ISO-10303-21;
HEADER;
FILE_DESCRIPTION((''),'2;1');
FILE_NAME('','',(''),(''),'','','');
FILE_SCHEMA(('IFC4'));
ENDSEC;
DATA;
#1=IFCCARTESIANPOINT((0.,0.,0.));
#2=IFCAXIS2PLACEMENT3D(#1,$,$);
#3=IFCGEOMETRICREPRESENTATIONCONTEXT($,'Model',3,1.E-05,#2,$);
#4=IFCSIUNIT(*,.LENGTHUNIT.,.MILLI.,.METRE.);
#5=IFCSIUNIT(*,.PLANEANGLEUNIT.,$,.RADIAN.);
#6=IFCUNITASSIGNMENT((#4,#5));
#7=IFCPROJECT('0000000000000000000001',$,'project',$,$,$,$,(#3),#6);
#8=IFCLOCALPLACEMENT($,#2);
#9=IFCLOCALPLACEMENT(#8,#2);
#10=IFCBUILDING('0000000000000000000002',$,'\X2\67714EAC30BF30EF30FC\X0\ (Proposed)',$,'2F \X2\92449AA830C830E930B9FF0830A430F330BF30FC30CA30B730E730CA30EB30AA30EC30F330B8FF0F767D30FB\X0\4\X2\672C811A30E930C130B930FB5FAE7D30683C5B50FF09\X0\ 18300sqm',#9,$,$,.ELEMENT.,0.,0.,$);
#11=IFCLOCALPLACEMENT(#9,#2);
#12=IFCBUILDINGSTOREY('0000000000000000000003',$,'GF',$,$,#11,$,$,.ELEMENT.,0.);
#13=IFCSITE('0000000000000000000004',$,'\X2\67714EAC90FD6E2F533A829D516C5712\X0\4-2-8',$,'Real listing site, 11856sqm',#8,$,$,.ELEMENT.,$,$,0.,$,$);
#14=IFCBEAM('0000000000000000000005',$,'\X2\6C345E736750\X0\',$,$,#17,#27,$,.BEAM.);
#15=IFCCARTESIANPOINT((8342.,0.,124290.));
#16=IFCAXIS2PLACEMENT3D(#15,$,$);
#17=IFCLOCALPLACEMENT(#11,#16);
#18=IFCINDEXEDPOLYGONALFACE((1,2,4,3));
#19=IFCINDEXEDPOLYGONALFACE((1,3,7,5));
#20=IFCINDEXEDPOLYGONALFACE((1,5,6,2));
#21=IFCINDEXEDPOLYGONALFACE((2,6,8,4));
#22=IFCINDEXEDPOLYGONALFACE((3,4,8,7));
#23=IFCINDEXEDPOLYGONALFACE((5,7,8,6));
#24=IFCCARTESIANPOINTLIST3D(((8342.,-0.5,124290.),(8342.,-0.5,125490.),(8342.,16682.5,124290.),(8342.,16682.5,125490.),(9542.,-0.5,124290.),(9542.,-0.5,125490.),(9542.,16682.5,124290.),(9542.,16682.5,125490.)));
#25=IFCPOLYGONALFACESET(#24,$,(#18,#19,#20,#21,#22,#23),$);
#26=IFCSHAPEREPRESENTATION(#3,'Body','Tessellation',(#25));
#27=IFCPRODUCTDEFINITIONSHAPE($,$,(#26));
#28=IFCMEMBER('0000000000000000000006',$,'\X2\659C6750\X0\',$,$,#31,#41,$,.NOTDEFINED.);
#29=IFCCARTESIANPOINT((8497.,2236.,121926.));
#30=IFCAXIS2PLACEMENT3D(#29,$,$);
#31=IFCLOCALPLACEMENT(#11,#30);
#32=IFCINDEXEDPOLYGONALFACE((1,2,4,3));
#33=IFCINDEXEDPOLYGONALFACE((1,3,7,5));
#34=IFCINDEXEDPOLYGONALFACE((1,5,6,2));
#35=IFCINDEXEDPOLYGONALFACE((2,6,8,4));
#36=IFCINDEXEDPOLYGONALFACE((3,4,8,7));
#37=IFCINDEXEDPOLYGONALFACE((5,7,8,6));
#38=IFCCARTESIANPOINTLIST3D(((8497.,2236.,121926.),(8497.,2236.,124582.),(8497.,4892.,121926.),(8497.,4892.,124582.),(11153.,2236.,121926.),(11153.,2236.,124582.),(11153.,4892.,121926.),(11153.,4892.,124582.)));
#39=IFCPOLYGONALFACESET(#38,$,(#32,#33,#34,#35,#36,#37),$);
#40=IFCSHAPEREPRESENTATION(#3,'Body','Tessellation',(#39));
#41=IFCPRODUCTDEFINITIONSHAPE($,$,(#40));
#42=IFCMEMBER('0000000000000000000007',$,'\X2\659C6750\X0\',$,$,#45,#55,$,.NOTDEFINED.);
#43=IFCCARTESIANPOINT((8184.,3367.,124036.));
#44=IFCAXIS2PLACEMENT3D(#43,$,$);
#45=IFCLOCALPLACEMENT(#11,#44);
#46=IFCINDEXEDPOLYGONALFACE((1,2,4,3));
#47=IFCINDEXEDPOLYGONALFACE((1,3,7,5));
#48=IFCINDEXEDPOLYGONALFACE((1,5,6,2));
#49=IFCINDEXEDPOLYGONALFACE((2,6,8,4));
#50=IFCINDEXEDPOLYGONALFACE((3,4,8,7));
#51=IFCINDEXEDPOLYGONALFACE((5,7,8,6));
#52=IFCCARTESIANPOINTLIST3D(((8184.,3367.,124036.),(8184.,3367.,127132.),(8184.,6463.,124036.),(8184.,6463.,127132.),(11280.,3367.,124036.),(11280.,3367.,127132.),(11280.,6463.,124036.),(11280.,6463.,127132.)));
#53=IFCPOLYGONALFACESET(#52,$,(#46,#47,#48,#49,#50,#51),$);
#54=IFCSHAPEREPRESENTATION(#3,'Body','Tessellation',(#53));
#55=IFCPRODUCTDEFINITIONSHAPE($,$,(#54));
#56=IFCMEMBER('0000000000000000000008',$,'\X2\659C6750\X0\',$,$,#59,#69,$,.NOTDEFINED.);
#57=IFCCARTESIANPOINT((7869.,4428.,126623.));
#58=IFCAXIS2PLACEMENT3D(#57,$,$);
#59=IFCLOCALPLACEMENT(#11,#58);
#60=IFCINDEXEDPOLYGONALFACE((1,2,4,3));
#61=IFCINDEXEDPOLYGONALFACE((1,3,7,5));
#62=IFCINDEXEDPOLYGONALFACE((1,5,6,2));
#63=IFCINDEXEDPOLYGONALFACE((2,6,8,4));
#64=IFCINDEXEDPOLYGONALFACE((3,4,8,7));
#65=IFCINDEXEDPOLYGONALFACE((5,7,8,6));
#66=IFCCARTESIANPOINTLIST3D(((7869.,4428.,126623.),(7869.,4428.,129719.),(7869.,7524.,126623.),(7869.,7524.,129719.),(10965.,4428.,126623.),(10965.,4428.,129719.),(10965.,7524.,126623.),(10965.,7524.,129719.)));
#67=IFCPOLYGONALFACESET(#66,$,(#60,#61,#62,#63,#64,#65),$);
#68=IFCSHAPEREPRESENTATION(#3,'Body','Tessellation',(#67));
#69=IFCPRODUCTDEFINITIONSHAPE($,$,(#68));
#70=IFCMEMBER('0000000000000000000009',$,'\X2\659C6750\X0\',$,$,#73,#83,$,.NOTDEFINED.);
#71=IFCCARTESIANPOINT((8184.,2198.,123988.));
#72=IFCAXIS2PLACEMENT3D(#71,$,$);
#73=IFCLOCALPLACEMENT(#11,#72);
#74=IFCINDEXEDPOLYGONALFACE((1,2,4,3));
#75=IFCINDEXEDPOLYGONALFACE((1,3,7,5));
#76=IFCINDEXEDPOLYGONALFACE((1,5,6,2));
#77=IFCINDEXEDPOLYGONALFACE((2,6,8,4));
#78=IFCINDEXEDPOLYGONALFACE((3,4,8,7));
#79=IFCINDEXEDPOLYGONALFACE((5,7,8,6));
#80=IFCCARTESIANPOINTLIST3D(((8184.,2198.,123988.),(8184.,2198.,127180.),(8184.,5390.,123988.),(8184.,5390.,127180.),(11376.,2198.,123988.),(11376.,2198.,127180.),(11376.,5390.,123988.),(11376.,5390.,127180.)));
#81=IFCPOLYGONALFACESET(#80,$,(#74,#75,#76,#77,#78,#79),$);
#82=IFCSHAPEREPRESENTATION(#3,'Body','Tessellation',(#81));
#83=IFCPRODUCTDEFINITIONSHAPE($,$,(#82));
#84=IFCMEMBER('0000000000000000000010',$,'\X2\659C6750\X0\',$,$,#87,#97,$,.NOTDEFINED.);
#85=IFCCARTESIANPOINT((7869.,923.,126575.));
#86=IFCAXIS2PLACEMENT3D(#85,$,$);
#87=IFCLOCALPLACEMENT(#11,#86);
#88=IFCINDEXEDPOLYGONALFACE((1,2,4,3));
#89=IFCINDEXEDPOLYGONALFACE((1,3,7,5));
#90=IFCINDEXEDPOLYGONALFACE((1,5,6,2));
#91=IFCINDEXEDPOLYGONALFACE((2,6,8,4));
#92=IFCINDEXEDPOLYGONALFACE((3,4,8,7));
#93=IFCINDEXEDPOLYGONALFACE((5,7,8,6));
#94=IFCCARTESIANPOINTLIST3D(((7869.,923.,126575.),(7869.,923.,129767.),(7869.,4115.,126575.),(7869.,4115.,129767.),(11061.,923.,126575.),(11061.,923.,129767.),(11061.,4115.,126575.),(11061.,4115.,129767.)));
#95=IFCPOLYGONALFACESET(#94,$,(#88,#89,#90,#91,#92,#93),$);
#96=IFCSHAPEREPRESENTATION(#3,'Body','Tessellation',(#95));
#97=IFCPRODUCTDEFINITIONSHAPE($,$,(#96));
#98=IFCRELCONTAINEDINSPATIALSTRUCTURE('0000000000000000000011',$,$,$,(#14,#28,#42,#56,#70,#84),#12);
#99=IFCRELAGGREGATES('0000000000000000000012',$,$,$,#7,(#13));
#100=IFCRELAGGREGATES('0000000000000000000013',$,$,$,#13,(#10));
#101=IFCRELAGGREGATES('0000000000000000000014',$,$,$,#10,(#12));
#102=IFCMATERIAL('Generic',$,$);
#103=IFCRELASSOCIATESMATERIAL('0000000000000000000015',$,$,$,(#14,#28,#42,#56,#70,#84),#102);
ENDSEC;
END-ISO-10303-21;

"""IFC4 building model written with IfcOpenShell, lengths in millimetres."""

from ifc_helpers import new_model, si_unit, frame, frame_2d, origin, place, context, project, spatial, rectangle, extrude, material, element, save


model = new_model("IFC4")

# Units and contexts
model_context = context("Model", 3, precision=1e-05, world=origin())
ifc_project = project(units=[si_unit("LENGTHUNIT", "METRE", prefix="MILLI"), si_unit("PLANEANGLEUNIT", "RADIAN")], contexts=[model_context])

# Site, building, storey
site_placement = place(None, origin())
site = spatial("IfcSite", under=ifc_project, at=site_placement, Name="東京都港区芝公園4-2-8", ObjectType="Real listing site, 11856sqm", CompositionType="ELEMENT", RefElevation=0.0)
building_placement = place(site_placement, origin())
building = spatial("IfcBuilding", under=site, at=building_placement, Name="東京タワー (Proposed)", ObjectType="2F 鉄骨トラス（インターナショナルオレンジ／白・4本脚ラチス・微細格子） 18300sqm", CompositionType="ELEMENT", ElevationOfRefHeight=0.0, ElevationOfTerrain=0.0)
storey_placement = place(building_placement, origin())
storey = spatial("IfcBuildingStorey", under=building, at=storey_placement, Name="GF", CompositionType="ELEMENT", Elevation=0.0)

# Shared definitions
ifc_material = material(Name="Generic")

# Beam
beam_placement = place(storey_placement, frame((8342.0, 0.0, 124290.0)))
element("IfcBeam", 1, at=beam_placement, inside=storey, material=ifc_material, Name="水平材", PredefinedType="BEAM", context=model_context, shape_type="SweptSolid", body=[
    extrude(rectangle(XDim=1200.0, YDim=16683.0, at=frame_2d((600.0, 8341.0))), frame((8342.0, 0.0, 124290.0)), (0.0, 0.0, 1.0), 1200.0),
])

# Members
member_1_placement = place(storey_placement, frame((8497.0, 2236.0, 121926.0)))
element("IfcMember", 2, at=member_1_placement, inside=storey, material=ifc_material, Name="斜材", PredefinedType="NOTDEFINED", context=model_context, shape_type="SweptSolid", body=[
    extrude(rectangle(XDim=2656.0, YDim=2656.0, at=frame_2d((1328.0, 1328.0))), frame((8497.0, 2236.0, 121926.0)), (0.0, 0.0, 1.0), 2656.0),
])
member_2_placement = place(storey_placement, frame((8184.0, 3367.0, 124036.0)))
element("IfcMember", 3, at=member_2_placement, inside=storey, material=ifc_material, Name="斜材", PredefinedType="NOTDEFINED", context=model_context, shape_type="SweptSolid", body=[
    extrude(rectangle(XDim=3096.0, YDim=3096.0, at=frame_2d((1548.0, 1548.0))), frame((8184.0, 3367.0, 124036.0)), (0.0, 0.0, 1.0), 3096.0),
])
member_3_placement = place(storey_placement, frame((7869.0, 4428.0, 126623.0)))
element("IfcMember", 4, at=member_3_placement, inside=storey, material=ifc_material, Name="斜材", PredefinedType="NOTDEFINED", context=model_context, shape_type="SweptSolid", body=[
    extrude(rectangle(XDim=3096.0, YDim=3096.0, at=frame_2d((1548.0, 1548.0))), frame((7869.0, 4428.0, 126623.0)), (0.0, 0.0, 1.0), 3096.0),
])
member_4_placement = place(storey_placement, frame((8184.0, 2198.0, 123988.0)))
element("IfcMember", 5, at=member_4_placement, inside=storey, material=ifc_material, Name="斜材", PredefinedType="NOTDEFINED", context=model_context, shape_type="SweptSolid", body=[
    extrude(rectangle(XDim=3192.0, YDim=3192.0, at=frame_2d((1596.0, 1596.0))), frame((8184.0, 2198.0, 123988.0)), (0.0, 0.0, 1.0), 3192.0),
])
member_5_placement = place(storey_placement, frame((7869.0, 923.0, 126575.0)))
element("IfcMember", 6, at=member_5_placement, inside=storey, material=ifc_material, Name="斜材", PredefinedType="NOTDEFINED", context=model_context, shape_type="SweptSolid", body=[
    extrude(rectangle(XDim=3192.0, YDim=3192.0, at=frame_2d((1596.0, 1596.0))), frame((7869.0, 923.0, 126575.0)), (0.0, 0.0, 1.0), 3192.0),
])

save(model, "model.ifc")
